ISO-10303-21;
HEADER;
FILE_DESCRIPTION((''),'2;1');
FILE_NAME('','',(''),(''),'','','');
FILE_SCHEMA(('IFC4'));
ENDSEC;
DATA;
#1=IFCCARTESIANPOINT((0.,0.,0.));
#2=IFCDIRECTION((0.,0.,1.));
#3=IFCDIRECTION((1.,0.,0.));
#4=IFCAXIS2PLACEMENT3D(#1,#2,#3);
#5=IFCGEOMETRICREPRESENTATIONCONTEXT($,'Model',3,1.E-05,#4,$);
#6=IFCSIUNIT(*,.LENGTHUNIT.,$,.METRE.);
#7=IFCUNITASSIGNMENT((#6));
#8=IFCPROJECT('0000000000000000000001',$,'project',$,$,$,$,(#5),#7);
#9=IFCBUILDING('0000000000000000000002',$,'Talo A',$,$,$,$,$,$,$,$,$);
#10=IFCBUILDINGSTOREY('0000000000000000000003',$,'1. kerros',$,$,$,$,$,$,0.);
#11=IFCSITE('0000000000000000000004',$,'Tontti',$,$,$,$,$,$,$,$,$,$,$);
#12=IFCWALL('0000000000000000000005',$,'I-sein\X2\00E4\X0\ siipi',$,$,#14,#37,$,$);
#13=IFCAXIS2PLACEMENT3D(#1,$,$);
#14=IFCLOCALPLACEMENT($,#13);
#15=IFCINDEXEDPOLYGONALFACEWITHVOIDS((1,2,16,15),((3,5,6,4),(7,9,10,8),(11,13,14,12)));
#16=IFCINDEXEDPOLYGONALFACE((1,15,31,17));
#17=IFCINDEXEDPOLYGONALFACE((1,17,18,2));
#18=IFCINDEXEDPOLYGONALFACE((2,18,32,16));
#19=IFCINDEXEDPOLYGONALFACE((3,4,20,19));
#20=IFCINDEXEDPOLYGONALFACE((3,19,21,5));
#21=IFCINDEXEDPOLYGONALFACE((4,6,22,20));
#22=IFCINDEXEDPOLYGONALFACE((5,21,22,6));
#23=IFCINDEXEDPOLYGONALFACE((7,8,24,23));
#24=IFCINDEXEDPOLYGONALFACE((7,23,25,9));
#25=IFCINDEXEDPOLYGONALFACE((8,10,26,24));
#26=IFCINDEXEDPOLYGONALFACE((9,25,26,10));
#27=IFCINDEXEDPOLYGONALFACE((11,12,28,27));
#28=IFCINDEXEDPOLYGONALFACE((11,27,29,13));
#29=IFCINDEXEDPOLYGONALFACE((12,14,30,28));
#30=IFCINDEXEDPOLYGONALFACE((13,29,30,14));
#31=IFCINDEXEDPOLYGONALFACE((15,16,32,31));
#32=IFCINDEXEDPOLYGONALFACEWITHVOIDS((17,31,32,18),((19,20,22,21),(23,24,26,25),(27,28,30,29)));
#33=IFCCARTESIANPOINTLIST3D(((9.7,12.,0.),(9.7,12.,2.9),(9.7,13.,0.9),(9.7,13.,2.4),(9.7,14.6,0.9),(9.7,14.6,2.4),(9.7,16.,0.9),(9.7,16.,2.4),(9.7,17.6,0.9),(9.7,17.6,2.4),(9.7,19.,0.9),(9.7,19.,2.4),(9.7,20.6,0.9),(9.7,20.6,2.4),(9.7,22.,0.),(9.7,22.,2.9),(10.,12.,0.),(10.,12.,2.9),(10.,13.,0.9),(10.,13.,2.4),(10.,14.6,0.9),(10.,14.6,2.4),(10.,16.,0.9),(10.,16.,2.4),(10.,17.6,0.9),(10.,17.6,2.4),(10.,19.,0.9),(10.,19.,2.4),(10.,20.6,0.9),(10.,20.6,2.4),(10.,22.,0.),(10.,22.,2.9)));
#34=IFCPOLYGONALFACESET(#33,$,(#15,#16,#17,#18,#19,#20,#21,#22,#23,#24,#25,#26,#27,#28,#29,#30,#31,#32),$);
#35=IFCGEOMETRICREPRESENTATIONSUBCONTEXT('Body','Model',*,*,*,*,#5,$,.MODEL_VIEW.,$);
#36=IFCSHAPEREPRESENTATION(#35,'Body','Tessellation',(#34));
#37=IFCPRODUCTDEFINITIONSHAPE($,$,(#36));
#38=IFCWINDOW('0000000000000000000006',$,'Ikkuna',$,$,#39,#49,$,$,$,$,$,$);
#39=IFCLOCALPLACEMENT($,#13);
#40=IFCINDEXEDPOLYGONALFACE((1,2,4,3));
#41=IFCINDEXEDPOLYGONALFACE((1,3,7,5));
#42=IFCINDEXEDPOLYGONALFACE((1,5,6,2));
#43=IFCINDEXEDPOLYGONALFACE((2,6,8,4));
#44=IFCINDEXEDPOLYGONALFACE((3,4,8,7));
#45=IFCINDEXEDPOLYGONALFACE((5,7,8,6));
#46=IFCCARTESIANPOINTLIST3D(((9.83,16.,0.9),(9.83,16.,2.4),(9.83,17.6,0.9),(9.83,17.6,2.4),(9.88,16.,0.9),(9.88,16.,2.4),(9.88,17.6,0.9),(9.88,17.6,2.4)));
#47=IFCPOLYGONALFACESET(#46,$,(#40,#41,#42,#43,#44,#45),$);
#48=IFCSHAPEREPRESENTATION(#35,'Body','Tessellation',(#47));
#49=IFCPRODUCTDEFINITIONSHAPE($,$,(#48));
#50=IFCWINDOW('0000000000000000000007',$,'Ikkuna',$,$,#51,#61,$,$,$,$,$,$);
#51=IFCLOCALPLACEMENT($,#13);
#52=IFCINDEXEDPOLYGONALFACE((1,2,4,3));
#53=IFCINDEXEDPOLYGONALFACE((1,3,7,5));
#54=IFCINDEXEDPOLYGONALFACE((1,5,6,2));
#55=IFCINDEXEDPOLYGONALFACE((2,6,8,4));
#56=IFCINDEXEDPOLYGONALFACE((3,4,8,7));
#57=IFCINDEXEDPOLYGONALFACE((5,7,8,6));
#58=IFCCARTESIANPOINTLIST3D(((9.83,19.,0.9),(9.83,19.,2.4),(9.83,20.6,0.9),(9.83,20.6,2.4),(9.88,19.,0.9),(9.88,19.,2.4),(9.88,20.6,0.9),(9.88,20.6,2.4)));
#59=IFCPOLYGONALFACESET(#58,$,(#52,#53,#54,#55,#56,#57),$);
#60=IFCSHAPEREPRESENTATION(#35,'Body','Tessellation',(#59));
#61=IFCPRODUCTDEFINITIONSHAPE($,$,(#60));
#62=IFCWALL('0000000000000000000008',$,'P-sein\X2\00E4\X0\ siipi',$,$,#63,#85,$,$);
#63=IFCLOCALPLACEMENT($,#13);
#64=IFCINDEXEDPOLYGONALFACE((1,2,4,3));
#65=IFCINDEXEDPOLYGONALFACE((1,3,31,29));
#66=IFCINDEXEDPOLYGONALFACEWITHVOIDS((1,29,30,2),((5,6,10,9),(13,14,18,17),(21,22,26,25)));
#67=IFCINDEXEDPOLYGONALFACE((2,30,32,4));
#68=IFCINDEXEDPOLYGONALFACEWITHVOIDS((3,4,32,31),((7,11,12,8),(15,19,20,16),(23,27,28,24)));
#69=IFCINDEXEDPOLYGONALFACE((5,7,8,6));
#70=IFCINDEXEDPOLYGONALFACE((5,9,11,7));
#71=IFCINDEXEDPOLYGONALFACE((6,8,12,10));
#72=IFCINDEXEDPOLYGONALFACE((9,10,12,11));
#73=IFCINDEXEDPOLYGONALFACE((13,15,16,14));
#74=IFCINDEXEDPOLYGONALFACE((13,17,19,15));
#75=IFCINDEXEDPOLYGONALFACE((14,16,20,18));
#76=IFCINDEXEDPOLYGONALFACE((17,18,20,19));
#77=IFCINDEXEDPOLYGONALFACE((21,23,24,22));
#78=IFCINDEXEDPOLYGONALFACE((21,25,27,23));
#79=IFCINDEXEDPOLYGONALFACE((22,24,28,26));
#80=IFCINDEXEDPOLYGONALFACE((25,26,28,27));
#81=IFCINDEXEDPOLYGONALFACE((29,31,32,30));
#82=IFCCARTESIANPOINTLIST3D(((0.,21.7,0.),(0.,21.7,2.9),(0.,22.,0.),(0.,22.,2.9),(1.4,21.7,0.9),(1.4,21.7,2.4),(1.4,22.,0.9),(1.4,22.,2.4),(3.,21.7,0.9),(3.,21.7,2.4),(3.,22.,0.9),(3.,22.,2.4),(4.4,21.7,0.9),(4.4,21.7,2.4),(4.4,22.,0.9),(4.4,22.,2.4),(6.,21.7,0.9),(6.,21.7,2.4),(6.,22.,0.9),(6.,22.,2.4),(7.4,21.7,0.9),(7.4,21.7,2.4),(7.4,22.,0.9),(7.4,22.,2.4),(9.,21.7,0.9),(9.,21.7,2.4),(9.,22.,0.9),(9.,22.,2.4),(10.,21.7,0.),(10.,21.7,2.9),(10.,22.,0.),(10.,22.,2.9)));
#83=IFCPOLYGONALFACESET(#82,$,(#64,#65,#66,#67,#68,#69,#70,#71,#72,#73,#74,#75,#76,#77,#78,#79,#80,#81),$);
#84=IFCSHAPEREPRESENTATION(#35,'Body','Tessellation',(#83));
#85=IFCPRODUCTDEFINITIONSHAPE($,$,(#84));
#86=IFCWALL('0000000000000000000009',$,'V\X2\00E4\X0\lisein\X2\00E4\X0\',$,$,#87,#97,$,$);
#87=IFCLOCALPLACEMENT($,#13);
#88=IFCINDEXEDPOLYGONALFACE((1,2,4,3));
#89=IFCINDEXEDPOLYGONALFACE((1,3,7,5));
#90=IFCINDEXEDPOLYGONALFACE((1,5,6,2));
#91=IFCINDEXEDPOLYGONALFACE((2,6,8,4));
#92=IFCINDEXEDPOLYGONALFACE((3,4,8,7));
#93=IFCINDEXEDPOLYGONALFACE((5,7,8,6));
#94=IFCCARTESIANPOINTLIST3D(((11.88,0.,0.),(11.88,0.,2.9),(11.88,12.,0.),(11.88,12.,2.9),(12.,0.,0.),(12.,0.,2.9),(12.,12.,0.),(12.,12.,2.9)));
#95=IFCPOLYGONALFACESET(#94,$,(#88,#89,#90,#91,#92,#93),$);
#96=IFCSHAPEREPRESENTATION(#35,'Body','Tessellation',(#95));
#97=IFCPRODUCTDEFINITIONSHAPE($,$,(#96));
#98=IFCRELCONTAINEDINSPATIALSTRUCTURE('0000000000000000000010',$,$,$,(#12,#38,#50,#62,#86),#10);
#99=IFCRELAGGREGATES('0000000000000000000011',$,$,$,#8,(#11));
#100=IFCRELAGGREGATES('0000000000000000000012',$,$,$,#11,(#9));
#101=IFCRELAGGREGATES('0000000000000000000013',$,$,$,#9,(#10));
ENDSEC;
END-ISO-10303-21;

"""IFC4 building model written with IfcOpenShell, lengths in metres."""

from ifc_helpers import new_model, si_unit, frame, origin_with_axes, place, context, subcontext, project, spatial, indexed_curve, outline, extrude, element, save


model = new_model("IFC4")

# Units and contexts
model_context = context("Model", 3, precision=1e-05, world=origin_with_axes())
body_context = subcontext(model_context, "Body", "Model", "MODEL_VIEW")
ifc_project = project(units=[si_unit("LENGTHUNIT", "METRE")], contexts=[model_context])

# Site, building, storey
site = spatial("IfcSite", under=ifc_project, Name="Tontti")
building = spatial("IfcBuilding", under=site, Name="Talo A")
storey = spatial("IfcBuildingStorey", under=building, Name="1. kerros", Elevation=0.0)

# Wall, openings
wall_1_placement = place(None, frame((10.0, 12.0, 0.0), z_axis=(0.0, 0.0, 1.0), x_axis=(0.0, 1.0, 0.0)))
wall_1 = element("IfcWall", 1, at=wall_1_placement, inside=storey, Name="I-seinä siipi", context=body_context, shape_type="SweptSolid", body=[
    extrude(outline(indexed_curve([(0.0, 0.0), (0.0, 0.3), (10.0, 0.3), (10.0, 0.0), (0.0, 0.0)], self_intersect=False)), origin_with_axes(), (0.0, 0.0, 1.0), 2.9),
])
opening_1_placement = place(wall_1_placement, frame((1.0, -0.1, 0.9), z_axis=(0.0, 0.0, 1.0), x_axis=(1.0, 0.0, 0.0)))
element("IfcOpeningElement", 2, at=opening_1_placement, cuts=wall_1, context=body_context, shape_type="SweptSolid", body=[
    extrude(outline(indexed_curve([(0.0, 0.0), (0.0, 0.5), (1.6, 0.5), (1.6, 0.0), (0.0, 0.0)], self_intersect=False)), origin_with_axes(), (0.0, 0.0, 1.0), 1.5),
])
opening_2_placement = place(wall_1_placement, frame((4.0, -0.1, 0.9), z_axis=(0.0, 0.0, 1.0), x_axis=(1.0, 0.0, 0.0)))
element("IfcOpeningElement", 3, at=opening_2_placement, cuts=wall_1, context=body_context, shape_type="SweptSolid", body=[
    extrude(outline(indexed_curve([(0.0, 0.0), (0.0, 0.5), (1.6, 0.5), (1.6, 0.0), (0.0, 0.0)], self_intersect=False)), origin_with_axes(), (0.0, 0.0, 1.0), 1.5),
])
opening_3_placement = place(wall_1_placement, frame((7.0, -0.1, 0.9), z_axis=(0.0, 0.0, 1.0), x_axis=(1.0, 0.0, 0.0)))
element("IfcOpeningElement", 4, at=opening_3_placement, cuts=wall_1, context=body_context, shape_type="SweptSolid", body=[
    extrude(outline(indexed_curve([(0.0, 0.0), (0.0, 0.5), (1.6, 0.5), (1.6, 0.0), (0.0, 0.0)], self_intersect=False)), origin_with_axes(), (0.0, 0.0, 1.0), 1.5),
])

# Windows
for number, where, z_axis, x_axis, name in (
    (5, (9.88, 16.0, 0.9), (0.0, 0.0, 1.0), (0.0, 1.0, 0.0), "Ikkuna"),
    (6, (9.88, 19.0, 0.9), (0.0, 0.0, 1.0), (0.0, 1.0, 0.0), "Ikkuna"),
):
    element("IfcWindow", number, at=place(None, frame(where, z_axis=z_axis, x_axis=x_axis)), inside=storey, Name=name, context=body_context, shape_type="SweptSolid", body=[
        extrude(outline(indexed_curve([(0.0, 0.0), (0.0, 0.05), (1.6, 0.05), (1.6, 0.0), (0.0, 0.0)], self_intersect=False)), origin_with_axes(), (0.0, 0.0, 1.0), 1.5),
    ])

# Wall, openings
wall_2_placement = place(None, frame((10.0, 22.0, 0.0), z_axis=(0.0, 0.0, 1.0), x_axis=(-1.0, 0.0, 0.0)))
wall_2 = element("IfcWall", 7, at=wall_2_placement, inside=storey, Name="P-seinä siipi", context=body_context, shape_type="SweptSolid", body=[
    extrude(outline(indexed_curve([(0.0, 0.0), (0.0, 0.3), (10.0, 0.3), (10.0, 0.0), (0.0, 0.0)], self_intersect=False)), origin_with_axes(), (0.0, 0.0, 1.0), 2.9),
])
opening_4_placement = place(wall_2_placement, frame((1.0, -0.1, 0.9), z_axis=(0.0, 0.0, 1.0), x_axis=(1.0, 0.0, 0.0)))
element("IfcOpeningElement", 8, at=opening_4_placement, cuts=wall_2, context=body_context, shape_type="SweptSolid", body=[
    extrude(outline(indexed_curve([(0.0, 0.0), (0.0, 0.5), (1.6, 0.5), (1.6, 0.0), (0.0, 0.0)], self_intersect=False)), origin_with_axes(), (0.0, 0.0, 1.0), 1.5),
])
opening_5_placement = place(wall_2_placement, frame((4.0, -0.1, 0.9), z_axis=(0.0, 0.0, 1.0), x_axis=(1.0, 0.0, 0.0)))
element("IfcOpeningElement", 9, at=opening_5_placement, cuts=wall_2, context=body_context, shape_type="SweptSolid", body=[
    extrude(outline(indexed_curve([(0.0, 0.0), (0.0, 0.5), (1.6, 0.5), (1.6, 0.0), (0.0, 0.0)], self_intersect=False)), origin_with_axes(), (0.0, 0.0, 1.0), 1.5),
])
opening_6_placement = place(wall_2_placement, frame((7.0, -0.1, 0.9), z_axis=(0.0, 0.0, 1.0), x_axis=(1.0, 0.0, 0.0)))
element("IfcOpeningElement", 10, at=opening_6_placement, cuts=wall_2, context=body_context, shape_type="SweptSolid", body=[
    extrude(outline(indexed_curve([(0.0, 0.0), (0.0, 0.5), (1.6, 0.5), (1.6, 0.0), (0.0, 0.0)], self_intersect=False)), origin_with_axes(), (0.0, 0.0, 1.0), 1.5),
])

# Wall
wall_3_placement = place(None, frame((12.0, 0.0, 0.0), z_axis=(0.0, 0.0, 1.0), x_axis=(0.0, 1.0, 0.0)))
element("IfcWall", 11, at=wall_3_placement, inside=storey, Name="Väliseinä", context=body_context, shape_type="SweptSolid", body=[
    extrude(outline(indexed_curve([(0.0, 0.0), (0.0, 0.12), (12.0, 0.12), (12.0, 0.0), (0.0, 0.0)], self_intersect=False)), origin_with_axes(), (0.0, 0.0, 1.0), 2.9),
])

save(model, "model.ifc")
